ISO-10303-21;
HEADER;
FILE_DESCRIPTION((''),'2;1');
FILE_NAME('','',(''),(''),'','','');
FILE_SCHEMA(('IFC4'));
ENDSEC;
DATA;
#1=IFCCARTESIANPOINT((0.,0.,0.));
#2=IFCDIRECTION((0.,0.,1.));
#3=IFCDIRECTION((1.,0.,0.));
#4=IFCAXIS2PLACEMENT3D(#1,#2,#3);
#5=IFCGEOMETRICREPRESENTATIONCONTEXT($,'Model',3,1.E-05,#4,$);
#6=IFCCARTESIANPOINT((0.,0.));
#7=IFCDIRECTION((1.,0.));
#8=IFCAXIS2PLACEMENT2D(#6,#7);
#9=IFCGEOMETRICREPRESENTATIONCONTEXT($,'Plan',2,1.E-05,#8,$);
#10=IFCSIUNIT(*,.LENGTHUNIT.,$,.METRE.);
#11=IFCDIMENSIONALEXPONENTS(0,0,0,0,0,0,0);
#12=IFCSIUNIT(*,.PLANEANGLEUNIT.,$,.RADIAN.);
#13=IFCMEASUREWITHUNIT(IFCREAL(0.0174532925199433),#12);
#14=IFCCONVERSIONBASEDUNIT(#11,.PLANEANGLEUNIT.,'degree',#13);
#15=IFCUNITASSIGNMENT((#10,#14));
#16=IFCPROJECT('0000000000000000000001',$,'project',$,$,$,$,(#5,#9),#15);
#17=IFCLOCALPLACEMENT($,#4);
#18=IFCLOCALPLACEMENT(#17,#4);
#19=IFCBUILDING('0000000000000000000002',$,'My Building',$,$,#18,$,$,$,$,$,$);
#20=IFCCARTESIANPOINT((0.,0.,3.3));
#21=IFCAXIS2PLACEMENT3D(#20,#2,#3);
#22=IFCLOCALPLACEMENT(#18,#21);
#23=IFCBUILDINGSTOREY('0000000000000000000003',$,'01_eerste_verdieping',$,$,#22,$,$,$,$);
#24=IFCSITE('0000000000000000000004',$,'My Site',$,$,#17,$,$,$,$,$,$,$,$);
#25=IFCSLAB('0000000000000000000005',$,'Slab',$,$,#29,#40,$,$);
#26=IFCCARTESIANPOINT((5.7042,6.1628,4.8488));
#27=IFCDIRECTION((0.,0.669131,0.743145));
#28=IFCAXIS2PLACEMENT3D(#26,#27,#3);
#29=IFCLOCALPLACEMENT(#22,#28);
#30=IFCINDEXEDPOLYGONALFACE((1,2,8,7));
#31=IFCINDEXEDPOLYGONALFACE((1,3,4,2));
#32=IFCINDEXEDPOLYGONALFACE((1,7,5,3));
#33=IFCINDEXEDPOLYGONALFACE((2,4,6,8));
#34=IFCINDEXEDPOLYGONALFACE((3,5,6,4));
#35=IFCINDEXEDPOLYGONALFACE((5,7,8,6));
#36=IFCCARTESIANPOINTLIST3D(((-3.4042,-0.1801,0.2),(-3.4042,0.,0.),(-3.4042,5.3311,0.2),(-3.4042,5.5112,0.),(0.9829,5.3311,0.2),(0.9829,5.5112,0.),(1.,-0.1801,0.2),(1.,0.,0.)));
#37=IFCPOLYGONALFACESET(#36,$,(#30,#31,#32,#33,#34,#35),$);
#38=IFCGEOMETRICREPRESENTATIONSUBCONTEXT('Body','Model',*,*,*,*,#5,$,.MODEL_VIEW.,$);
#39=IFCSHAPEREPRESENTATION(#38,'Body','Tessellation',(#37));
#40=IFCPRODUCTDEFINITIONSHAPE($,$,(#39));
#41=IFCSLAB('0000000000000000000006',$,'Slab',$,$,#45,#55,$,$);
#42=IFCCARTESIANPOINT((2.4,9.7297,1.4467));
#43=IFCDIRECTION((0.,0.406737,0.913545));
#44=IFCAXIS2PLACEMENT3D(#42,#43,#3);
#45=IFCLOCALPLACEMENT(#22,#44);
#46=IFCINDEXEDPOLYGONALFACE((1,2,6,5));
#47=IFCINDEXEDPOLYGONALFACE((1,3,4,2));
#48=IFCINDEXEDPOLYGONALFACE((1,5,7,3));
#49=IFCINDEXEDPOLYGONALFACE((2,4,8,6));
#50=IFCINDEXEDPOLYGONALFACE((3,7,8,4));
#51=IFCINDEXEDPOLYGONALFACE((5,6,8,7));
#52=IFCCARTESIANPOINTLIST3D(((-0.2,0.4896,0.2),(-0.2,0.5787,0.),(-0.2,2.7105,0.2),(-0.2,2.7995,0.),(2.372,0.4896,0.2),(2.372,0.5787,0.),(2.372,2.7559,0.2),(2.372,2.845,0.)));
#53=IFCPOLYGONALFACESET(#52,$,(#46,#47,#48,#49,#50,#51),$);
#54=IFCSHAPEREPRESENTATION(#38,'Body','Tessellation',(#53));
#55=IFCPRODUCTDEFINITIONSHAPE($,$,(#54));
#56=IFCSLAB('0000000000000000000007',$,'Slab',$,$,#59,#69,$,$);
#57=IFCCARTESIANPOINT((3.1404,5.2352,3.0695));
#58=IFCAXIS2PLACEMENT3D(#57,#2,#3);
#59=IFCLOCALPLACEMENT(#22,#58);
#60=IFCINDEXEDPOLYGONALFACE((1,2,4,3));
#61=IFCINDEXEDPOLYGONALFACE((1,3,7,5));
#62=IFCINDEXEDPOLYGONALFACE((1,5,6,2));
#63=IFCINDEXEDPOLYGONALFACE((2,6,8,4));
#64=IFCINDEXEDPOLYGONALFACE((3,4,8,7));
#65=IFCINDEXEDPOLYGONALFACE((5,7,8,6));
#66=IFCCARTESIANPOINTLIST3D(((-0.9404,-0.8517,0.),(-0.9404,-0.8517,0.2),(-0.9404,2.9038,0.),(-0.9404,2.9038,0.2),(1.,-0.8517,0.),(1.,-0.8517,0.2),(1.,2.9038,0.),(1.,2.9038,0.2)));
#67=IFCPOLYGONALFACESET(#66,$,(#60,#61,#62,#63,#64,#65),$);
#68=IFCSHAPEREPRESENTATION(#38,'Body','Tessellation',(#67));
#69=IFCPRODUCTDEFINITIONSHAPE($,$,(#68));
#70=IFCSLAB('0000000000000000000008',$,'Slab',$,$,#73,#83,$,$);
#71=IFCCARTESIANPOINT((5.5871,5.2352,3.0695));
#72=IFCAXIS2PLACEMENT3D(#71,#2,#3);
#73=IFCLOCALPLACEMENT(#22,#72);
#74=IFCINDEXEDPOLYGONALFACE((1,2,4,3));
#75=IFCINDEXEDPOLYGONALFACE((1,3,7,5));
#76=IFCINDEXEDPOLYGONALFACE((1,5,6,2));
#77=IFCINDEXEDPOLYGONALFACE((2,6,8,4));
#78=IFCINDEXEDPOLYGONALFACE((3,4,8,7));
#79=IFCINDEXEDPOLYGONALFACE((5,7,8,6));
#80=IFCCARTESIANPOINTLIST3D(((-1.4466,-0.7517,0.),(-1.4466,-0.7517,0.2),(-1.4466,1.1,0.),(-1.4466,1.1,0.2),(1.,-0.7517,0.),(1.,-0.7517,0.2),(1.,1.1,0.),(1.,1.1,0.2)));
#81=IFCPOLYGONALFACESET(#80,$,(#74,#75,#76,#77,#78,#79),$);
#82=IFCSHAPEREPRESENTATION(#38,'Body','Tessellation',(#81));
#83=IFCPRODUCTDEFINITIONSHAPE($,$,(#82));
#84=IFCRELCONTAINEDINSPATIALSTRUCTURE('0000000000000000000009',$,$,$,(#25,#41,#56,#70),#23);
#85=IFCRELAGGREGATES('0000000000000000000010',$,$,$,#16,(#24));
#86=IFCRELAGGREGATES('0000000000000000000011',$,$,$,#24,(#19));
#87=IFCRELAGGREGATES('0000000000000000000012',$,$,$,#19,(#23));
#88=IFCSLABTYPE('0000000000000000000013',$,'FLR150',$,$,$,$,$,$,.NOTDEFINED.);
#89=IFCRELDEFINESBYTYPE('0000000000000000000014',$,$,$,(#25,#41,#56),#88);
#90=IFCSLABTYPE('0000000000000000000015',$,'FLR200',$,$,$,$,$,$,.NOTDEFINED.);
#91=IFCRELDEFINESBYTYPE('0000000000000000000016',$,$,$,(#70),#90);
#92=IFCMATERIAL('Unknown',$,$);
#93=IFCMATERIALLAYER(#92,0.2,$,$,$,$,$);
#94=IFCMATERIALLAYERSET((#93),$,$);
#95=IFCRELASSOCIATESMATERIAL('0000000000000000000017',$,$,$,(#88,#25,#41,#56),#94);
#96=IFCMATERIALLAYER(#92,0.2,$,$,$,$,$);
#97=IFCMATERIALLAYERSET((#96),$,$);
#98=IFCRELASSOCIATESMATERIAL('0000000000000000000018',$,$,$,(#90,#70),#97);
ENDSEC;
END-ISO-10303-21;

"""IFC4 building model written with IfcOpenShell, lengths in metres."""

from ifc_helpers import new_model, entity, si_unit, converted_unit, frame, origin_with_axes, origin_2d_with_axis, place, context, subcontext, project, spatial, line, indexed_curve, outline, extrude, material, layer, layer_set, layer_usage, type_object, element, save


model = new_model("IFC4")

# Units and contexts
model_context = context("Model", 3, precision=1e-05, world=origin_with_axes())
plan_context = context("Plan", 2, precision=1e-05, world=origin_2d_with_axis())
body_context_1 = subcontext(model_context, "Body", "Model", "MODEL_VIEW")
ifc_project = project(units=[si_unit("LENGTHUNIT", "METRE"), converted_unit("PLANEANGLEUNIT", "degree", entity("IfcReal", 0.0174532925199433), si_unit("PLANEANGLEUNIT", "RADIAN"), dimensions=[0, 0, 0, 0, 0, 0, 0])], contexts=[model_context, plan_context])

# Site, building, storey
site_placement = place(None, origin_with_axes())
site = spatial("IfcSite", under=ifc_project, at=site_placement, Name="My Site")
building_placement = place(site_placement, origin_with_axes())
building = spatial("IfcBuilding", under=site, at=building_placement, Name="My Building")
storey_placement = place(building_placement, frame((0.0, 0.0, 3.3), z_axis=(0.0, 0.0, 1.0), x_axis=(1.0, 0.0, 0.0)))
storey = spatial("IfcBuildingStorey", under=building, at=storey_placement, Name="01_eerste_verdieping")

# Slabs
ifc_material = material(Name="Unknown")
ifc_layer_1 = layer(ifc_material, 0.2)
ifc_layer_set_1 = layer_set([ifc_layer_1])
slab_type_1 = type_object("IfcSlabType", Name="FLR150", PredefinedType="NOTDEFINED", material=ifc_layer_set_1)
ifc_layer_usage_1 = layer_usage(ifc_layer_set_1, "AXIS3", "POSITIVE", 0.0)
slab_1_placement = place(storey_placement, frame((5.7042, 6.1628, 4.8488), z_axis=(0.0, 0.669131, 0.743145), x_axis=(1.0, 0.0, 0.0)))
element("IfcSlab", 1, at=slab_1_placement, inside=storey, type_object=slab_type_1, material=ifc_layer_usage_1, Name="Slab", context=body_context_1, shape_type="SweptSolid", body=[
    extrude(outline(indexed_curve([(1.0, 0.0), (-3.4042, 0.0), (-3.4042, 5.5112), (0.9829, 5.5112)], segments=[line(4, 1), line(1, 2), line(2, 3), line(3, 4)], self_intersect=False)), None, (0.0, -0.669131, 0.743145), 0.2691),
])
ifc_layer_usage_2 = layer_usage(ifc_layer_set_1, "AXIS3", "POSITIVE", 0.0)
slab_2_placement = place(storey_placement, frame((2.4, 9.7297, 1.4467), z_axis=(0.0, 0.406737, 0.913545), x_axis=(1.0, 0.0, 0.0)))
element("IfcSlab", 2, at=slab_2_placement, inside=storey, type_object=slab_type_1, material=ifc_layer_usage_2, Name="Slab", context=body_context_1, shape_type="SweptSolid", body=[
    extrude(outline(indexed_curve([(-0.2, 2.7995), (2.372, 2.845), (2.372, 0.5787), (-0.2, 0.5787)], segments=[line(4, 1), line(1, 2), line(2, 3), line(3, 4)], self_intersect=False)), None, (0.0, -0.406737, 0.913545), 0.2189),
])
ifc_layer_usage_3 = layer_usage(ifc_layer_set_1, "AXIS3", "POSITIVE", 0.0)
slab_3_placement = place(storey_placement, frame((3.1404, 5.2352, 3.0695), z_axis=(0.0, 0.0, 1.0), x_axis=(1.0, 0.0, 0.0)))
element("IfcSlab", 3, at=slab_3_placement, inside=storey, type_object=slab_type_1, material=ifc_layer_usage_3, Name="Slab", context=body_context_1, shape_type="SweptSolid", body=[
    extrude(outline(indexed_curve([(-0.9404, -0.8517), (1.0, -0.8517), (1.0, 2.9038), (-0.9404, 2.9038)], segments=[line(3, 2), line(2, 1), line(1, 4), line(4, 3)], self_intersect=False)), None, (0.0, 0.0, 1.0), 0.2),
])
ifc_layer_2 = layer(ifc_material, 0.2)
ifc_layer_set_2 = layer_set([ifc_layer_2])
ifc_layer_usage_4 = layer_usage(ifc_layer_set_2, "AXIS3", "POSITIVE", 0.0)
slab_type_2 = type_object("IfcSlabType", Name="FLR200", PredefinedType="NOTDEFINED", material=ifc_layer_set_2)
slab_4_placement = place(storey_placement, frame((5.5871, 5.2352, 3.0695), z_axis=(0.0, 0.0, 1.0), x_axis=(1.0, 0.0, 0.0)))
element("IfcSlab", 4, at=slab_4_placement, inside=storey, type_object=slab_type_2, material=ifc_layer_usage_4, Name="Slab", context=body_context_1, shape_type="SweptSolid", body=[
    extrude(outline(indexed_curve([(1.0, 1.1), (1.0, -0.7517), (-1.4466, -0.7517), (-1.4466, 1.1)], segments=[line(3, 2), line(2, 1), line(1, 4), line(4, 3)], self_intersect=False)), None, (0.0, 0.0, 1.0), 0.2),
])

save(model, "model.ifc")
